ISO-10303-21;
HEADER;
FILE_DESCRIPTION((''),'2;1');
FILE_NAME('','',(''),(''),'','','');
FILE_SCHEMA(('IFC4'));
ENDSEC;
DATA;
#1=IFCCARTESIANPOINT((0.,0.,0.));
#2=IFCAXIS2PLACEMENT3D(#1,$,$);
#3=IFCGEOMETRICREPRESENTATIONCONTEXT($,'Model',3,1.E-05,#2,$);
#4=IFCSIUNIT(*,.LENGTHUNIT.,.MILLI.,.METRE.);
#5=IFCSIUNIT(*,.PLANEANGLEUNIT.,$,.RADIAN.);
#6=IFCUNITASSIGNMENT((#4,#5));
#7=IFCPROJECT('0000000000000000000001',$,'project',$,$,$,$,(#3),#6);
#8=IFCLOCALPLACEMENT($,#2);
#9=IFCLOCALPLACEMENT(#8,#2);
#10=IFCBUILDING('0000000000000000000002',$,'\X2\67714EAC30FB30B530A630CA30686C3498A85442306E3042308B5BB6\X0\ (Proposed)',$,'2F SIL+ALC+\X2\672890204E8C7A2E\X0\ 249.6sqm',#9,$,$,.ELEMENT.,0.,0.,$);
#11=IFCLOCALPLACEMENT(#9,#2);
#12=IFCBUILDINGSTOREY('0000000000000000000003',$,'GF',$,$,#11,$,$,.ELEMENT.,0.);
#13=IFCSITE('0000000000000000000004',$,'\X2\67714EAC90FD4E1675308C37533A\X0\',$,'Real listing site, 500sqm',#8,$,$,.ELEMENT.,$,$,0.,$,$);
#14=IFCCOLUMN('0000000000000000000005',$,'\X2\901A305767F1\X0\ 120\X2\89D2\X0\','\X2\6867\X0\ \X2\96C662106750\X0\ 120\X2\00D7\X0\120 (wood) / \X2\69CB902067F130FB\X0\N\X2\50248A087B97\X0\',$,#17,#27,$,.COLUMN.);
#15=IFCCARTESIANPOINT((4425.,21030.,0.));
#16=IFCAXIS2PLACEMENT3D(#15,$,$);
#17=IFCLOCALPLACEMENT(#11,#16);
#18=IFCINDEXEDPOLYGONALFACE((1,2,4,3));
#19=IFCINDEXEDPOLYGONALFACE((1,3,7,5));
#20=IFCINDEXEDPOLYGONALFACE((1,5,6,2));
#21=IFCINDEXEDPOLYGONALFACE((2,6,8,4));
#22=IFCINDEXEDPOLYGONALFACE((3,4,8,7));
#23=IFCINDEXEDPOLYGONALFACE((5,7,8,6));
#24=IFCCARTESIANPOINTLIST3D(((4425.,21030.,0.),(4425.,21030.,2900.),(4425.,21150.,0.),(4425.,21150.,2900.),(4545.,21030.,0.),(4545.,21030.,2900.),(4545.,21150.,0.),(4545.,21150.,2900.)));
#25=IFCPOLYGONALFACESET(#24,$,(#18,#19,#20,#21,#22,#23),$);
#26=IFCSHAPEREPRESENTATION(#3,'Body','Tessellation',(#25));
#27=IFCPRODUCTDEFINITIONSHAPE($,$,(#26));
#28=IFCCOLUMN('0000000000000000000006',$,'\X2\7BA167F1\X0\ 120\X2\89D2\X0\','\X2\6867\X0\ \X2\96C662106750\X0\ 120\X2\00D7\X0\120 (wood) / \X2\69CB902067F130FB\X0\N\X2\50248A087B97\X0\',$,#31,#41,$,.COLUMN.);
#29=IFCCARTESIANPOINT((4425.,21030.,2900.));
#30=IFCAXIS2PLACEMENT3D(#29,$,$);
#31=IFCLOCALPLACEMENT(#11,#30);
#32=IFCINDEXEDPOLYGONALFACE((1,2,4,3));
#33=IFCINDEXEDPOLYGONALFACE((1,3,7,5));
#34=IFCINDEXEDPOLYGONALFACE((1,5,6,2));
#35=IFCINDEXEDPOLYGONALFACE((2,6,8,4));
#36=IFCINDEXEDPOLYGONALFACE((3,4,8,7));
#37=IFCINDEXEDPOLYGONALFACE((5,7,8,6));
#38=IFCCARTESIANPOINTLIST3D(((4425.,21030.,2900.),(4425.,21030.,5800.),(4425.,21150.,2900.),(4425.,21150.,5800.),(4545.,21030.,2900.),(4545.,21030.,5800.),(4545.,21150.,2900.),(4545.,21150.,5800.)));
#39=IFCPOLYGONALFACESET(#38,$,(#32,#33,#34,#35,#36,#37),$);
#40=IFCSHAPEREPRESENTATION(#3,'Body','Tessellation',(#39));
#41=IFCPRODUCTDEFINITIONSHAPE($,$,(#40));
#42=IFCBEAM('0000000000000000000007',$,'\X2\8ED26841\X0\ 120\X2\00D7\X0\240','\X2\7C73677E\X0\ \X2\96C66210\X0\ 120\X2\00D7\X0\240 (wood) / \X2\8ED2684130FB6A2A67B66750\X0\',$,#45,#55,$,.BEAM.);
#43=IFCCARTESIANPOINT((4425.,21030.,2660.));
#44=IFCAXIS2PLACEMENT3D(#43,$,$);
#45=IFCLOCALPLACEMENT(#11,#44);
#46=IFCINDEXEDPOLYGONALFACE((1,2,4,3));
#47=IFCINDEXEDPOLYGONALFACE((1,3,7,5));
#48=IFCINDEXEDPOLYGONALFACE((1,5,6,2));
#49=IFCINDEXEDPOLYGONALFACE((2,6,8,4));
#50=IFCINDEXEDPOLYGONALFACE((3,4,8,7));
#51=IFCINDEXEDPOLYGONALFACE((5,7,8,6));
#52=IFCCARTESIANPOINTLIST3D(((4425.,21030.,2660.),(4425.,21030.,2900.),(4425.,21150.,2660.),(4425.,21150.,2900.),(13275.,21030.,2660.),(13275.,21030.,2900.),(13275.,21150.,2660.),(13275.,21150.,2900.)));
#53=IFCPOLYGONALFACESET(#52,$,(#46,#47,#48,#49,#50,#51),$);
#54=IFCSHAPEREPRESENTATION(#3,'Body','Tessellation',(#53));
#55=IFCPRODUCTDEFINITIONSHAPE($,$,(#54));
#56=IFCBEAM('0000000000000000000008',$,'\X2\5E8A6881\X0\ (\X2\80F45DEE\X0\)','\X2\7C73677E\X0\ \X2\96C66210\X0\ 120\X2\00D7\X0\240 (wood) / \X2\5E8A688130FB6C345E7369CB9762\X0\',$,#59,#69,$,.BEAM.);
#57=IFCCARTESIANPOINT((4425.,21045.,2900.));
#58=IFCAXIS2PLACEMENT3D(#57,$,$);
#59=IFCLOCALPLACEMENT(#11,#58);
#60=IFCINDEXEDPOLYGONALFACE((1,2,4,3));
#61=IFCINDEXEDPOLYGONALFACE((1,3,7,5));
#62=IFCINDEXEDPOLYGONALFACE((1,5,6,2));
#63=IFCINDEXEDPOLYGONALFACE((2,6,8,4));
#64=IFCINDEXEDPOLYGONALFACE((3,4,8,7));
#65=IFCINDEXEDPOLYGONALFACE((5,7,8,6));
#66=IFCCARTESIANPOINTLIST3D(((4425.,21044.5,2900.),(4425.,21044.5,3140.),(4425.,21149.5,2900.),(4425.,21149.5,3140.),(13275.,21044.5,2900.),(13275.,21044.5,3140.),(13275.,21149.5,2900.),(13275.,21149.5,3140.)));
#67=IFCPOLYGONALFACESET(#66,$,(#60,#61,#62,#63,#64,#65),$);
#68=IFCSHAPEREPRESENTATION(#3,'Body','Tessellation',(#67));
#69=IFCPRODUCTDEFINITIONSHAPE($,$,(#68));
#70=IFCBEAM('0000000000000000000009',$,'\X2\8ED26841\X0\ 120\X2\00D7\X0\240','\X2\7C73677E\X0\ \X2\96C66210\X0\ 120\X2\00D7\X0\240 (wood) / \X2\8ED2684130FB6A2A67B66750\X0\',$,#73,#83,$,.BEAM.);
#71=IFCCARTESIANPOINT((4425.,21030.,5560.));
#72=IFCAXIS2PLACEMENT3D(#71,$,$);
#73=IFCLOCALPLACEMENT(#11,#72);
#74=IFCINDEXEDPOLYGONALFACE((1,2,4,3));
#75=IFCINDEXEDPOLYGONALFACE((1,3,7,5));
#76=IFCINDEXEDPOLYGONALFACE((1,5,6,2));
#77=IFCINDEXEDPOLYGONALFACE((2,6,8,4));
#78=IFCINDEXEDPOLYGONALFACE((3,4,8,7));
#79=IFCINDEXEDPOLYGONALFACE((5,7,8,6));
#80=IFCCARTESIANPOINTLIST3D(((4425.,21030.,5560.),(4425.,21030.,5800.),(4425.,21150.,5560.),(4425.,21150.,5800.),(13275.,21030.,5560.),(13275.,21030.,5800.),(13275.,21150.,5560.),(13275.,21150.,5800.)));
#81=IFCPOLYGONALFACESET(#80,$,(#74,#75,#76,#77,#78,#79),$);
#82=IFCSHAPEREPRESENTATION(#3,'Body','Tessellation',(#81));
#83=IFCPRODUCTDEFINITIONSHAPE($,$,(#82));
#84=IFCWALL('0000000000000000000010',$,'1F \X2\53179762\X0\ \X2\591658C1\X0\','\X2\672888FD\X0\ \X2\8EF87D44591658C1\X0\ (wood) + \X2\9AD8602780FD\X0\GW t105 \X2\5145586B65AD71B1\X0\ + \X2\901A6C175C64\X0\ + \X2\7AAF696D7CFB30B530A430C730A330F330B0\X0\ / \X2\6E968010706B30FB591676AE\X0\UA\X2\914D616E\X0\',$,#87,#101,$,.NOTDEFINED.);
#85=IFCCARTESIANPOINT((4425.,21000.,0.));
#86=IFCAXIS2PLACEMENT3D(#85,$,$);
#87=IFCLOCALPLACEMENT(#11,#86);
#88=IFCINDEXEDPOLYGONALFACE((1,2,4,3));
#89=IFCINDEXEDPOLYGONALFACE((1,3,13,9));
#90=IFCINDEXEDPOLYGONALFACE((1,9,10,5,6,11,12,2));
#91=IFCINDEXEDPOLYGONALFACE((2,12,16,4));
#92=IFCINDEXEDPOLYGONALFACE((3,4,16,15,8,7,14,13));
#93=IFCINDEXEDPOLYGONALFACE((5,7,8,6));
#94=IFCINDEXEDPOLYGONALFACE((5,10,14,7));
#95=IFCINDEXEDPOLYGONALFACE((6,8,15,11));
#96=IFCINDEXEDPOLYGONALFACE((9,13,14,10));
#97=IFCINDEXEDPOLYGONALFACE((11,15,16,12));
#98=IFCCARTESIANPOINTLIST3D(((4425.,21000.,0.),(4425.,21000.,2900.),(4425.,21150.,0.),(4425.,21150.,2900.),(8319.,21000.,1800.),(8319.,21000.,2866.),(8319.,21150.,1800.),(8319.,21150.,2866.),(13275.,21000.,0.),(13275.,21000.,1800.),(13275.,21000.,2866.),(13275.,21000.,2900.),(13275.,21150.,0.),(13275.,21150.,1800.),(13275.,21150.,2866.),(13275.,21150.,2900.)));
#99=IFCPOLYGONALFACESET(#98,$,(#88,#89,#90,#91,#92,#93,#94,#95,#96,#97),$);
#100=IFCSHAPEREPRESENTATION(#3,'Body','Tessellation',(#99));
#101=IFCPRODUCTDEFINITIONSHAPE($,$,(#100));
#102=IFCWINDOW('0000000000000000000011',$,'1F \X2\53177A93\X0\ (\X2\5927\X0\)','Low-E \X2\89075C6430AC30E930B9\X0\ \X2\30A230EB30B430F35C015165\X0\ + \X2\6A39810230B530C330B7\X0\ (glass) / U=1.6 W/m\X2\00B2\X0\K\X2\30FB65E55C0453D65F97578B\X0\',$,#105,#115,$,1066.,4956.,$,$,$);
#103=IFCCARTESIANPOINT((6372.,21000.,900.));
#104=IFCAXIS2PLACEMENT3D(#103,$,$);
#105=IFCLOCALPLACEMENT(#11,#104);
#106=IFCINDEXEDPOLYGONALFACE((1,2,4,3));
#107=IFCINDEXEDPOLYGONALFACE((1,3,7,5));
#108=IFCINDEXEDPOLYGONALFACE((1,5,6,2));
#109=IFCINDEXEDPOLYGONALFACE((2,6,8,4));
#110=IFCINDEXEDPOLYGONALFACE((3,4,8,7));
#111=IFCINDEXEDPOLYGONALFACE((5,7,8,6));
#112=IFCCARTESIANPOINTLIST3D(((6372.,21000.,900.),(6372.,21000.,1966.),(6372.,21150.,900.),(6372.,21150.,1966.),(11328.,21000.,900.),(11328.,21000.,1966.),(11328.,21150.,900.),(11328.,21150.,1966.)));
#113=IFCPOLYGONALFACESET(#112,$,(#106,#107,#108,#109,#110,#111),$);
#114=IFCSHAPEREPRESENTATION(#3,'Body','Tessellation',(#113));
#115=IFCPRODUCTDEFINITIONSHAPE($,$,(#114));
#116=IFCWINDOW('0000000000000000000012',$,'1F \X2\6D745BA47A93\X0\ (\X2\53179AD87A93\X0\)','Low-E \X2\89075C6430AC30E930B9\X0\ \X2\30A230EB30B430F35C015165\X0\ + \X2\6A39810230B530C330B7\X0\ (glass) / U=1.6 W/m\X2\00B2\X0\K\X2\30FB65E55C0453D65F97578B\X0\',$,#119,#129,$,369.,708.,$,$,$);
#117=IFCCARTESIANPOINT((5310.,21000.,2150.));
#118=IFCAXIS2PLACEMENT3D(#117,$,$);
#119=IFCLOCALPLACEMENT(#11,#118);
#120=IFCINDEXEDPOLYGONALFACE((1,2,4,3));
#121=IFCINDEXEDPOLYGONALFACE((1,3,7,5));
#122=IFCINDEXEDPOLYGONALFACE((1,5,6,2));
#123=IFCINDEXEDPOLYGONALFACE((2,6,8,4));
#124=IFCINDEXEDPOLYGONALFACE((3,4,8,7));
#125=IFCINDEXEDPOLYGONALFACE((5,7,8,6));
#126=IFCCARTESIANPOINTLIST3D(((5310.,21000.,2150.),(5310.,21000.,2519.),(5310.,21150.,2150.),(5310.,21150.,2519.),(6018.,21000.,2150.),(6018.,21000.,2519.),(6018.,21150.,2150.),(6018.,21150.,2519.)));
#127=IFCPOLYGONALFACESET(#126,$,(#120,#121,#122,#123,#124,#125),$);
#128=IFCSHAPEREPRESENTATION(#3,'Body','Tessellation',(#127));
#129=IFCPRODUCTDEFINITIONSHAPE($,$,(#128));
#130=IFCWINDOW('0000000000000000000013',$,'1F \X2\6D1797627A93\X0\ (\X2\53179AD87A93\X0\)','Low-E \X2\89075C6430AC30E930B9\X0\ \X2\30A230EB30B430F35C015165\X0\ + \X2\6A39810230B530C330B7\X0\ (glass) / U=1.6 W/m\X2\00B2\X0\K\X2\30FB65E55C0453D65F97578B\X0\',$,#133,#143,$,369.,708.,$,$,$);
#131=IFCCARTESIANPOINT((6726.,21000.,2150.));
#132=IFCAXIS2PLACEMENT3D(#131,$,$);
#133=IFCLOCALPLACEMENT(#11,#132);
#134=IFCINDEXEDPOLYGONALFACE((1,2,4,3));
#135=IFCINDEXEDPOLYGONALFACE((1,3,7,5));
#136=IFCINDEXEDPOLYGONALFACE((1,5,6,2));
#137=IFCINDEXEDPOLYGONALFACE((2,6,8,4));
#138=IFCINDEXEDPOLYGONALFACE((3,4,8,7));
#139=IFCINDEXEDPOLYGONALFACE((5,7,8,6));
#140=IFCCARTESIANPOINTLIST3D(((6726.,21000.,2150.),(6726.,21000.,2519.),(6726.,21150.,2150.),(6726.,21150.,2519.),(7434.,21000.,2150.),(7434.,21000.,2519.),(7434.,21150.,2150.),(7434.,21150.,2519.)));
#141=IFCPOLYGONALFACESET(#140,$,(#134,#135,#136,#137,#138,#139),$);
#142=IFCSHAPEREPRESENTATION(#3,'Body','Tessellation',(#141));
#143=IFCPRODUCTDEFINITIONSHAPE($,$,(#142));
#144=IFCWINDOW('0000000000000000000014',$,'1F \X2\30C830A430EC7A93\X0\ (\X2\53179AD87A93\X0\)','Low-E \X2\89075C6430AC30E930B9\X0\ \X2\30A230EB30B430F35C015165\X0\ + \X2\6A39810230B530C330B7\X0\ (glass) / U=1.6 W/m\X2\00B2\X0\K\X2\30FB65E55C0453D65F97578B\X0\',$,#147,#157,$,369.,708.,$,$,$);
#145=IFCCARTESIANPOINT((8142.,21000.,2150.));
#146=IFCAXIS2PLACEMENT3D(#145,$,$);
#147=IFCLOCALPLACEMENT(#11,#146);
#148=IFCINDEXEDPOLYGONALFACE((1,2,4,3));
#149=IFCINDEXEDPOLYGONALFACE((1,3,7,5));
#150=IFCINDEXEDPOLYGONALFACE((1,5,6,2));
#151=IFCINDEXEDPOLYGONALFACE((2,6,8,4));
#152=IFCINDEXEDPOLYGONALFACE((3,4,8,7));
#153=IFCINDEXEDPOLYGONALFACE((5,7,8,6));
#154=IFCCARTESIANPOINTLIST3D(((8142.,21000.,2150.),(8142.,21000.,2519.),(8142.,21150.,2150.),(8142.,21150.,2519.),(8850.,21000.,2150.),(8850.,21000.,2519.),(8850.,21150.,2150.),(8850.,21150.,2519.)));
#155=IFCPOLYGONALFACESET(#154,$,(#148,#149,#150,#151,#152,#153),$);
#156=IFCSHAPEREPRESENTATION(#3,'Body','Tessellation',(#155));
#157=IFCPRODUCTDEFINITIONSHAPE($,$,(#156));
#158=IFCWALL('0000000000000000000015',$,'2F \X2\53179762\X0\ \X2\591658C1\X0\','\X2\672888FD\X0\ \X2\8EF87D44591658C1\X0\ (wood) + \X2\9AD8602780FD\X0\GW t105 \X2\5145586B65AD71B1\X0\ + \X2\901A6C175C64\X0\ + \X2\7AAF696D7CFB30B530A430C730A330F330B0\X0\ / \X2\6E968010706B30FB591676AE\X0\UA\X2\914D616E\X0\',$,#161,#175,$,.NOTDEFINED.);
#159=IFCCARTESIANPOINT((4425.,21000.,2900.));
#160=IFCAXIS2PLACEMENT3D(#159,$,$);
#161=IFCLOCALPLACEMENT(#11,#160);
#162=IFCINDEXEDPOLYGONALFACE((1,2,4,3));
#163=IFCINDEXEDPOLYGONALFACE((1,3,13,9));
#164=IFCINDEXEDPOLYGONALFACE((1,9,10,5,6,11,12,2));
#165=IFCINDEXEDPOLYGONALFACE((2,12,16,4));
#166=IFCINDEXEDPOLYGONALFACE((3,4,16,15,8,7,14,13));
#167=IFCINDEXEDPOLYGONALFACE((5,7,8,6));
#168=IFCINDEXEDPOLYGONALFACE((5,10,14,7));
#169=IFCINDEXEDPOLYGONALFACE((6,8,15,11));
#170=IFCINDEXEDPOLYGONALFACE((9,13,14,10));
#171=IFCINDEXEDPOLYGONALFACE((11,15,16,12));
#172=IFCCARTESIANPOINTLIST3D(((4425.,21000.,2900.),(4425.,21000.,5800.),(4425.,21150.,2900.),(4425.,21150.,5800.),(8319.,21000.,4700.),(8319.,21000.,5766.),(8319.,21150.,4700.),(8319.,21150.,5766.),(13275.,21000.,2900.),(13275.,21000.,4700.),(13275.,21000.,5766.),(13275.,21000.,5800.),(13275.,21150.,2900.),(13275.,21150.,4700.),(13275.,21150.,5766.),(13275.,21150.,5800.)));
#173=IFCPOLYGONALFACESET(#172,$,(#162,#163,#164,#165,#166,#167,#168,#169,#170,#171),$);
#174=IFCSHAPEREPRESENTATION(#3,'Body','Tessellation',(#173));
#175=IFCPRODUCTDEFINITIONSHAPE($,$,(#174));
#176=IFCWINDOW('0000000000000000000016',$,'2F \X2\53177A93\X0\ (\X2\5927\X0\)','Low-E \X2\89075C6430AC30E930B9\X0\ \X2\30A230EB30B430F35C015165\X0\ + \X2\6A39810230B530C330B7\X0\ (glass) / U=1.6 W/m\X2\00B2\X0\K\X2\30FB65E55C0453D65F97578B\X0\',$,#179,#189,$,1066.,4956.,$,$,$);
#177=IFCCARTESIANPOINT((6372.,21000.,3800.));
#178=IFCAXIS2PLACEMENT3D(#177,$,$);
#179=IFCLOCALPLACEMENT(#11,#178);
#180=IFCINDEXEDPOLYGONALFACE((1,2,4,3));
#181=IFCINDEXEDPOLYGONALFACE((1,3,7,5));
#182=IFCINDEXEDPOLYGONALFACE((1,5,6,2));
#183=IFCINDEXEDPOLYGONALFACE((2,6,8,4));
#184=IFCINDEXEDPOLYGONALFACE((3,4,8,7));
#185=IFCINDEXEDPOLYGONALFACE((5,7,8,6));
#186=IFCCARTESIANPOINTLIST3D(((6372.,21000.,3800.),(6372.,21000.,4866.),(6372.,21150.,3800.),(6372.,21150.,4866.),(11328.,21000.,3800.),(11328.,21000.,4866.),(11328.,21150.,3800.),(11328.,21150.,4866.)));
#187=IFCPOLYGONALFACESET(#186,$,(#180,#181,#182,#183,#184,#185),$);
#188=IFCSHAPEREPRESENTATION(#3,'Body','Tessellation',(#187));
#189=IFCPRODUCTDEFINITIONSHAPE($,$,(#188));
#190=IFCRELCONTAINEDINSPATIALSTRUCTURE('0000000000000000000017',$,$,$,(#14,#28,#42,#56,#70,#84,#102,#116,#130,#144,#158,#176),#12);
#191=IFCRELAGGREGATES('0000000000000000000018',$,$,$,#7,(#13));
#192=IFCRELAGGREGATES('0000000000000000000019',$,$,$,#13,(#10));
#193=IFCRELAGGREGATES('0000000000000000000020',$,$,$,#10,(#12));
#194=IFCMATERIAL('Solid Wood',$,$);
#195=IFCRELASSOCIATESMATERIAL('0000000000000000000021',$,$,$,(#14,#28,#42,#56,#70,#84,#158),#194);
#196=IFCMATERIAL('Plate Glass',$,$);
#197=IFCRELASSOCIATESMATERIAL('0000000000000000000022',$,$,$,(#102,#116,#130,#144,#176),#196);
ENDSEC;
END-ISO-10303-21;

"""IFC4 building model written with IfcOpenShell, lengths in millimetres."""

from ifc_helpers import new_model, si_unit, frame, frame_2d, origin, place, context, project, spatial, rectangle, extrude, material, element, fill, save


model = new_model("IFC4")

# Units and contexts
model_context = context("Model", 3, precision=1e-05, world=origin())
ifc_project = project(units=[si_unit("LENGTHUNIT", "METRE", prefix="MILLI"), si_unit("PLANEANGLEUNIT", "RADIAN")], contexts=[model_context])

# Site, building, storey
site_placement = place(None, origin())
site = spatial("IfcSite", under=ifc_project, at=site_placement, Name="東京都世田谷区", ObjectType="Real listing site, 500sqm", CompositionType="ELEMENT", RefElevation=0.0)
building_placement = place(site_placement, origin())
building = spatial("IfcBuilding", under=site, at=building_placement, Name="東京・サウナと水風呂のある家 (Proposed)", ObjectType="2F SIL+ALC+木造二種 249.6sqm", CompositionType="ELEMENT", ElevationOfRefHeight=0.0, ElevationOfTerrain=0.0)
storey_placement = place(building_placement, origin())
storey = spatial("IfcBuildingStorey", under=building, at=storey_placement, Name="GF", CompositionType="ELEMENT", Elevation=0.0)

# Columns
ifc_material_1 = material(Name="Solid Wood")
column_1_placement = place(storey_placement, frame((4425.0, 21030.0, 0.0)))
element("IfcColumn", 1, at=column_1_placement, inside=storey, material=ifc_material_1, Name="通し柱 120角", Description="桧 集成材 120×120 (wood) / 構造柱・N値計算", PredefinedType="COLUMN", context=model_context, shape_type="SweptSolid", body=[
    extrude(rectangle(XDim=120.0, YDim=120.0, at=frame_2d((60.0, 60.0))), frame((4425.0, 21030.0, 0.0)), (0.0, 0.0, 1.0), 2900.0),
])
column_2_placement = place(storey_placement, frame((4425.0, 21030.0, 2900.0)))
element("IfcColumn", 2, at=column_2_placement, inside=storey, material=ifc_material_1, Name="管柱 120角", Description="桧 集成材 120×120 (wood) / 構造柱・N値計算", PredefinedType="COLUMN", context=model_context, shape_type="SweptSolid", body=[
    extrude(rectangle(XDim=120.0, YDim=120.0, at=frame_2d((60.0, 60.0))), frame((4425.0, 21030.0, 2900.0)), (0.0, 0.0, 1.0), 2900.0),
])

# Beams
beam_1_placement = place(storey_placement, frame((4425.0, 21030.0, 2660.0)))
element("IfcBeam", 3, at=beam_1_placement, inside=storey, material=ifc_material_1, Name="軒桁 120×240", Description="米松 集成 120×240 (wood) / 軒桁・横架材", PredefinedType="BEAM", context=model_context, shape_type="SweptSolid", body=[
    extrude(rectangle(XDim=8850.0, YDim=120.0, at=frame_2d((4425.0, 60.0))), frame((4425.0, 21030.0, 2660.0)), (0.0, 0.0, 1.0), 240.0),
])
beam_2_placement = place(storey_placement, frame((4425.0, 21045.0, 2900.0)))
element("IfcBeam", 4, at=beam_2_placement, inside=storey, material=ifc_material_1, Name="床梁 (胴差)", Description="米松 集成 120×240 (wood) / 床梁・水平構面", PredefinedType="BEAM", context=model_context, shape_type="SweptSolid", body=[
    extrude(rectangle(XDim=8850.0, YDim=105.0, at=frame_2d((4425.0, 52.0))), frame((4425.0, 21045.0, 2900.0)), (0.0, 0.0, 1.0), 240.0),
])
beam_3_placement = place(storey_placement, frame((4425.0, 21030.0, 5560.0)))
element("IfcBeam", 5, at=beam_3_placement, inside=storey, material=ifc_material_1, Name="軒桁 120×240", Description="米松 集成 120×240 (wood) / 軒桁・横架材", PredefinedType="BEAM", context=model_context, shape_type="SweptSolid", body=[
    extrude(rectangle(XDim=8850.0, YDim=120.0, at=frame_2d((4425.0, 60.0))), frame((4425.0, 21030.0, 5560.0)), (0.0, 0.0, 1.0), 240.0),
])

# Wall, openings, windows
wall_1_placement = place(storey_placement, frame((4425.0, 21000.0, 0.0)))
wall_1 = element("IfcWall", 6, at=wall_1_placement, inside=storey, material=ifc_material_1, Name="1F 北面 外壁", Description="木製 軸組外壁 (wood) + 高性能GW t105 充填断熱 + 通気層 + 窯業系サイディング / 準耐火・外皮UA配慮", PredefinedType="NOTDEFINED", context=model_context, shape_type="SweptSolid", body=[
    extrude(rectangle(XDim=8850.0, YDim=150.0, at=frame_2d((4425.0, 75.0))), frame((4425.0, 21000.0, 0.0)), (0.0, 0.0, 1.0), 2900.0),
])
opening_1_placement = place(storey_placement, frame((6372.0, 21000.0, 900.0)))
opening_1 = element("IfcOpeningElement", 7, at=opening_1_placement, cuts=wall_1, PredefinedType="NOTDEFINED", context=model_context, shape_type="SweptSolid", body=[
    extrude(rectangle(XDim=4956.0, YDim=150.0, at=frame_2d((2478.0, 75.0))), frame((6372.0, 21000.0, 900.0)), (0.0, 0.0, 1.0), 1066.0),
])
opening_2_placement = place(storey_placement, frame((5310.0, 21000.0, 2150.0)))
opening_2 = element("IfcOpeningElement", 8, at=opening_2_placement, cuts=wall_1, PredefinedType="NOTDEFINED", context=model_context, shape_type="SweptSolid", body=[
    extrude(rectangle(XDim=708.0, YDim=150.0, at=frame_2d((354.0, 75.0))), frame((5310.0, 21000.0, 2150.0)), (0.0, 0.0, 1.0), 369.0),
])
opening_3_placement = place(storey_placement, frame((6726.0, 21000.0, 2150.0)))
opening_3 = element("IfcOpeningElement", 9, at=opening_3_placement, cuts=wall_1, PredefinedType="NOTDEFINED", context=model_context, shape_type="SweptSolid", body=[
    extrude(rectangle(XDim=708.0, YDim=150.0, at=frame_2d((354.0, 75.0))), frame((6726.0, 21000.0, 2150.0)), (0.0, 0.0, 1.0), 369.0),
])
opening_4_placement = place(storey_placement, frame((8142.0, 21000.0, 2150.0)))
opening_4 = element("IfcOpeningElement", 10, at=opening_4_placement, cuts=wall_1, PredefinedType="NOTDEFINED", context=model_context, shape_type="SweptSolid", body=[
    extrude(rectangle(XDim=708.0, YDim=150.0, at=frame_2d((354.0, 75.0))), frame((8142.0, 21000.0, 2150.0)), (0.0, 0.0, 1.0), 369.0),
])
ifc_material_2 = material(Name="Plate Glass")
window_1_placement = place(storey_placement, frame((6372.0, 21000.0, 900.0)))
window_1 = element("IfcWindow", 11, at=window_1_placement, inside=storey, material=ifc_material_2, Name="1F 北窓 (大)", Description="Low-E 複層ガラス アルゴン封入 + 樹脂サッシ (glass) / U=1.6 W/m²K・日射取得型", OverallHeight=1066.0, OverallWidth=4956.0, context=model_context, shape_type="SweptSolid", body=[
    extrude(rectangle(XDim=4956.0, YDim=150.0, at=frame_2d((2478.0, 75.0))), frame((6372.0, 21000.0, 900.0)), (0.0, 0.0, 1.0), 1066.0),
])
fill(opening_1, window_1)
window_2_placement = place(storey_placement, frame((5310.0, 21000.0, 2150.0)))
window_2 = element("IfcWindow", 12, at=window_2_placement, inside=storey, material=ifc_material_2, Name="1F 浴室窓 (北高窓)", Description="Low-E 複層ガラス アルゴン封入 + 樹脂サッシ (glass) / U=1.6 W/m²K・日射取得型", OverallHeight=369.0, OverallWidth=708.0, context=model_context, shape_type="SweptSolid", body=[
    extrude(rectangle(XDim=708.0, YDim=150.0, at=frame_2d((354.0, 75.0))), frame((5310.0, 21000.0, 2150.0)), (0.0, 0.0, 1.0), 369.0),
])
fill(opening_2, window_2)
window_3_placement = place(storey_placement, frame((6726.0, 21000.0, 2150.0)))
window_3 = element("IfcWindow", 13, at=window_3_placement, inside=storey, material=ifc_material_2, Name="1F 洗面窓 (北高窓)", Description="Low-E 複層ガラス アルゴン封入 + 樹脂サッシ (glass) / U=1.6 W/m²K・日射取得型", OverallHeight=369.0, OverallWidth=708.0, context=model_context, shape_type="SweptSolid", body=[
    extrude(rectangle(XDim=708.0, YDim=150.0, at=frame_2d((354.0, 75.0))), frame((6726.0, 21000.0, 2150.0)), (0.0, 0.0, 1.0), 369.0),
])
fill(opening_3, window_3)
window_4_placement = place(storey_placement, frame((8142.0, 21000.0, 2150.0)))
window_4 = element("IfcWindow", 14, at=window_4_placement, inside=storey, material=ifc_material_2, Name="1F トイレ窓 (北高窓)", Description="Low-E 複層ガラス アルゴン封入 + 樹脂サッシ (glass) / U=1.6 W/m²K・日射取得型", OverallHeight=369.0, OverallWidth=708.0, context=model_context, shape_type="SweptSolid", body=[
    extrude(rectangle(XDim=708.0, YDim=150.0, at=frame_2d((354.0, 75.0))), frame((8142.0, 21000.0, 2150.0)), (0.0, 0.0, 1.0), 369.0),
])
fill(opening_4, window_4)

# Wall, opening, window
wall_2_placement = place(storey_placement, frame((4425.0, 21000.0, 2900.0)))
wall_2 = element("IfcWall", 15, at=wall_2_placement, inside=storey, material=ifc_material_1, Name="2F 北面 外壁", Description="木製 軸組外壁 (wood) + 高性能GW t105 充填断熱 + 通気層 + 窯業系サイディング / 準耐火・外皮UA配慮", PredefinedType="NOTDEFINED", context=model_context, shape_type="SweptSolid", body=[
    extrude(rectangle(XDim=8850.0, YDim=150.0, at=frame_2d((4425.0, 75.0))), frame((4425.0, 21000.0, 2900.0)), (0.0, 0.0, 1.0), 2900.0),
])
opening_5_placement = place(storey_placement, frame((6372.0, 21000.0, 3800.0)))
opening_5 = element("IfcOpeningElement", 16, at=opening_5_placement, cuts=wall_2, PredefinedType="NOTDEFINED", context=model_context, shape_type="SweptSolid", body=[
    extrude(rectangle(XDim=4956.0, YDim=150.0, at=frame_2d((2478.0, 75.0))), frame((6372.0, 21000.0, 3800.0)), (0.0, 0.0, 1.0), 1066.0),
])
window_5_placement = place(storey_placement, frame((6372.0, 21000.0, 3800.0)))
window_5 = element("IfcWindow", 17, at=window_5_placement, inside=storey, material=ifc_material_2, Name="2F 北窓 (大)", Description="Low-E 複層ガラス アルゴン封入 + 樹脂サッシ (glass) / U=1.6 W/m²K・日射取得型", OverallHeight=1066.0, OverallWidth=4956.0, context=model_context, shape_type="SweptSolid", body=[
    extrude(rectangle(XDim=4956.0, YDim=150.0, at=frame_2d((2478.0, 75.0))), frame((6372.0, 21000.0, 3800.0)), (0.0, 0.0, 1.0), 1066.0),
])
fill(opening_5, window_5)

save(model, "model.ifc")
